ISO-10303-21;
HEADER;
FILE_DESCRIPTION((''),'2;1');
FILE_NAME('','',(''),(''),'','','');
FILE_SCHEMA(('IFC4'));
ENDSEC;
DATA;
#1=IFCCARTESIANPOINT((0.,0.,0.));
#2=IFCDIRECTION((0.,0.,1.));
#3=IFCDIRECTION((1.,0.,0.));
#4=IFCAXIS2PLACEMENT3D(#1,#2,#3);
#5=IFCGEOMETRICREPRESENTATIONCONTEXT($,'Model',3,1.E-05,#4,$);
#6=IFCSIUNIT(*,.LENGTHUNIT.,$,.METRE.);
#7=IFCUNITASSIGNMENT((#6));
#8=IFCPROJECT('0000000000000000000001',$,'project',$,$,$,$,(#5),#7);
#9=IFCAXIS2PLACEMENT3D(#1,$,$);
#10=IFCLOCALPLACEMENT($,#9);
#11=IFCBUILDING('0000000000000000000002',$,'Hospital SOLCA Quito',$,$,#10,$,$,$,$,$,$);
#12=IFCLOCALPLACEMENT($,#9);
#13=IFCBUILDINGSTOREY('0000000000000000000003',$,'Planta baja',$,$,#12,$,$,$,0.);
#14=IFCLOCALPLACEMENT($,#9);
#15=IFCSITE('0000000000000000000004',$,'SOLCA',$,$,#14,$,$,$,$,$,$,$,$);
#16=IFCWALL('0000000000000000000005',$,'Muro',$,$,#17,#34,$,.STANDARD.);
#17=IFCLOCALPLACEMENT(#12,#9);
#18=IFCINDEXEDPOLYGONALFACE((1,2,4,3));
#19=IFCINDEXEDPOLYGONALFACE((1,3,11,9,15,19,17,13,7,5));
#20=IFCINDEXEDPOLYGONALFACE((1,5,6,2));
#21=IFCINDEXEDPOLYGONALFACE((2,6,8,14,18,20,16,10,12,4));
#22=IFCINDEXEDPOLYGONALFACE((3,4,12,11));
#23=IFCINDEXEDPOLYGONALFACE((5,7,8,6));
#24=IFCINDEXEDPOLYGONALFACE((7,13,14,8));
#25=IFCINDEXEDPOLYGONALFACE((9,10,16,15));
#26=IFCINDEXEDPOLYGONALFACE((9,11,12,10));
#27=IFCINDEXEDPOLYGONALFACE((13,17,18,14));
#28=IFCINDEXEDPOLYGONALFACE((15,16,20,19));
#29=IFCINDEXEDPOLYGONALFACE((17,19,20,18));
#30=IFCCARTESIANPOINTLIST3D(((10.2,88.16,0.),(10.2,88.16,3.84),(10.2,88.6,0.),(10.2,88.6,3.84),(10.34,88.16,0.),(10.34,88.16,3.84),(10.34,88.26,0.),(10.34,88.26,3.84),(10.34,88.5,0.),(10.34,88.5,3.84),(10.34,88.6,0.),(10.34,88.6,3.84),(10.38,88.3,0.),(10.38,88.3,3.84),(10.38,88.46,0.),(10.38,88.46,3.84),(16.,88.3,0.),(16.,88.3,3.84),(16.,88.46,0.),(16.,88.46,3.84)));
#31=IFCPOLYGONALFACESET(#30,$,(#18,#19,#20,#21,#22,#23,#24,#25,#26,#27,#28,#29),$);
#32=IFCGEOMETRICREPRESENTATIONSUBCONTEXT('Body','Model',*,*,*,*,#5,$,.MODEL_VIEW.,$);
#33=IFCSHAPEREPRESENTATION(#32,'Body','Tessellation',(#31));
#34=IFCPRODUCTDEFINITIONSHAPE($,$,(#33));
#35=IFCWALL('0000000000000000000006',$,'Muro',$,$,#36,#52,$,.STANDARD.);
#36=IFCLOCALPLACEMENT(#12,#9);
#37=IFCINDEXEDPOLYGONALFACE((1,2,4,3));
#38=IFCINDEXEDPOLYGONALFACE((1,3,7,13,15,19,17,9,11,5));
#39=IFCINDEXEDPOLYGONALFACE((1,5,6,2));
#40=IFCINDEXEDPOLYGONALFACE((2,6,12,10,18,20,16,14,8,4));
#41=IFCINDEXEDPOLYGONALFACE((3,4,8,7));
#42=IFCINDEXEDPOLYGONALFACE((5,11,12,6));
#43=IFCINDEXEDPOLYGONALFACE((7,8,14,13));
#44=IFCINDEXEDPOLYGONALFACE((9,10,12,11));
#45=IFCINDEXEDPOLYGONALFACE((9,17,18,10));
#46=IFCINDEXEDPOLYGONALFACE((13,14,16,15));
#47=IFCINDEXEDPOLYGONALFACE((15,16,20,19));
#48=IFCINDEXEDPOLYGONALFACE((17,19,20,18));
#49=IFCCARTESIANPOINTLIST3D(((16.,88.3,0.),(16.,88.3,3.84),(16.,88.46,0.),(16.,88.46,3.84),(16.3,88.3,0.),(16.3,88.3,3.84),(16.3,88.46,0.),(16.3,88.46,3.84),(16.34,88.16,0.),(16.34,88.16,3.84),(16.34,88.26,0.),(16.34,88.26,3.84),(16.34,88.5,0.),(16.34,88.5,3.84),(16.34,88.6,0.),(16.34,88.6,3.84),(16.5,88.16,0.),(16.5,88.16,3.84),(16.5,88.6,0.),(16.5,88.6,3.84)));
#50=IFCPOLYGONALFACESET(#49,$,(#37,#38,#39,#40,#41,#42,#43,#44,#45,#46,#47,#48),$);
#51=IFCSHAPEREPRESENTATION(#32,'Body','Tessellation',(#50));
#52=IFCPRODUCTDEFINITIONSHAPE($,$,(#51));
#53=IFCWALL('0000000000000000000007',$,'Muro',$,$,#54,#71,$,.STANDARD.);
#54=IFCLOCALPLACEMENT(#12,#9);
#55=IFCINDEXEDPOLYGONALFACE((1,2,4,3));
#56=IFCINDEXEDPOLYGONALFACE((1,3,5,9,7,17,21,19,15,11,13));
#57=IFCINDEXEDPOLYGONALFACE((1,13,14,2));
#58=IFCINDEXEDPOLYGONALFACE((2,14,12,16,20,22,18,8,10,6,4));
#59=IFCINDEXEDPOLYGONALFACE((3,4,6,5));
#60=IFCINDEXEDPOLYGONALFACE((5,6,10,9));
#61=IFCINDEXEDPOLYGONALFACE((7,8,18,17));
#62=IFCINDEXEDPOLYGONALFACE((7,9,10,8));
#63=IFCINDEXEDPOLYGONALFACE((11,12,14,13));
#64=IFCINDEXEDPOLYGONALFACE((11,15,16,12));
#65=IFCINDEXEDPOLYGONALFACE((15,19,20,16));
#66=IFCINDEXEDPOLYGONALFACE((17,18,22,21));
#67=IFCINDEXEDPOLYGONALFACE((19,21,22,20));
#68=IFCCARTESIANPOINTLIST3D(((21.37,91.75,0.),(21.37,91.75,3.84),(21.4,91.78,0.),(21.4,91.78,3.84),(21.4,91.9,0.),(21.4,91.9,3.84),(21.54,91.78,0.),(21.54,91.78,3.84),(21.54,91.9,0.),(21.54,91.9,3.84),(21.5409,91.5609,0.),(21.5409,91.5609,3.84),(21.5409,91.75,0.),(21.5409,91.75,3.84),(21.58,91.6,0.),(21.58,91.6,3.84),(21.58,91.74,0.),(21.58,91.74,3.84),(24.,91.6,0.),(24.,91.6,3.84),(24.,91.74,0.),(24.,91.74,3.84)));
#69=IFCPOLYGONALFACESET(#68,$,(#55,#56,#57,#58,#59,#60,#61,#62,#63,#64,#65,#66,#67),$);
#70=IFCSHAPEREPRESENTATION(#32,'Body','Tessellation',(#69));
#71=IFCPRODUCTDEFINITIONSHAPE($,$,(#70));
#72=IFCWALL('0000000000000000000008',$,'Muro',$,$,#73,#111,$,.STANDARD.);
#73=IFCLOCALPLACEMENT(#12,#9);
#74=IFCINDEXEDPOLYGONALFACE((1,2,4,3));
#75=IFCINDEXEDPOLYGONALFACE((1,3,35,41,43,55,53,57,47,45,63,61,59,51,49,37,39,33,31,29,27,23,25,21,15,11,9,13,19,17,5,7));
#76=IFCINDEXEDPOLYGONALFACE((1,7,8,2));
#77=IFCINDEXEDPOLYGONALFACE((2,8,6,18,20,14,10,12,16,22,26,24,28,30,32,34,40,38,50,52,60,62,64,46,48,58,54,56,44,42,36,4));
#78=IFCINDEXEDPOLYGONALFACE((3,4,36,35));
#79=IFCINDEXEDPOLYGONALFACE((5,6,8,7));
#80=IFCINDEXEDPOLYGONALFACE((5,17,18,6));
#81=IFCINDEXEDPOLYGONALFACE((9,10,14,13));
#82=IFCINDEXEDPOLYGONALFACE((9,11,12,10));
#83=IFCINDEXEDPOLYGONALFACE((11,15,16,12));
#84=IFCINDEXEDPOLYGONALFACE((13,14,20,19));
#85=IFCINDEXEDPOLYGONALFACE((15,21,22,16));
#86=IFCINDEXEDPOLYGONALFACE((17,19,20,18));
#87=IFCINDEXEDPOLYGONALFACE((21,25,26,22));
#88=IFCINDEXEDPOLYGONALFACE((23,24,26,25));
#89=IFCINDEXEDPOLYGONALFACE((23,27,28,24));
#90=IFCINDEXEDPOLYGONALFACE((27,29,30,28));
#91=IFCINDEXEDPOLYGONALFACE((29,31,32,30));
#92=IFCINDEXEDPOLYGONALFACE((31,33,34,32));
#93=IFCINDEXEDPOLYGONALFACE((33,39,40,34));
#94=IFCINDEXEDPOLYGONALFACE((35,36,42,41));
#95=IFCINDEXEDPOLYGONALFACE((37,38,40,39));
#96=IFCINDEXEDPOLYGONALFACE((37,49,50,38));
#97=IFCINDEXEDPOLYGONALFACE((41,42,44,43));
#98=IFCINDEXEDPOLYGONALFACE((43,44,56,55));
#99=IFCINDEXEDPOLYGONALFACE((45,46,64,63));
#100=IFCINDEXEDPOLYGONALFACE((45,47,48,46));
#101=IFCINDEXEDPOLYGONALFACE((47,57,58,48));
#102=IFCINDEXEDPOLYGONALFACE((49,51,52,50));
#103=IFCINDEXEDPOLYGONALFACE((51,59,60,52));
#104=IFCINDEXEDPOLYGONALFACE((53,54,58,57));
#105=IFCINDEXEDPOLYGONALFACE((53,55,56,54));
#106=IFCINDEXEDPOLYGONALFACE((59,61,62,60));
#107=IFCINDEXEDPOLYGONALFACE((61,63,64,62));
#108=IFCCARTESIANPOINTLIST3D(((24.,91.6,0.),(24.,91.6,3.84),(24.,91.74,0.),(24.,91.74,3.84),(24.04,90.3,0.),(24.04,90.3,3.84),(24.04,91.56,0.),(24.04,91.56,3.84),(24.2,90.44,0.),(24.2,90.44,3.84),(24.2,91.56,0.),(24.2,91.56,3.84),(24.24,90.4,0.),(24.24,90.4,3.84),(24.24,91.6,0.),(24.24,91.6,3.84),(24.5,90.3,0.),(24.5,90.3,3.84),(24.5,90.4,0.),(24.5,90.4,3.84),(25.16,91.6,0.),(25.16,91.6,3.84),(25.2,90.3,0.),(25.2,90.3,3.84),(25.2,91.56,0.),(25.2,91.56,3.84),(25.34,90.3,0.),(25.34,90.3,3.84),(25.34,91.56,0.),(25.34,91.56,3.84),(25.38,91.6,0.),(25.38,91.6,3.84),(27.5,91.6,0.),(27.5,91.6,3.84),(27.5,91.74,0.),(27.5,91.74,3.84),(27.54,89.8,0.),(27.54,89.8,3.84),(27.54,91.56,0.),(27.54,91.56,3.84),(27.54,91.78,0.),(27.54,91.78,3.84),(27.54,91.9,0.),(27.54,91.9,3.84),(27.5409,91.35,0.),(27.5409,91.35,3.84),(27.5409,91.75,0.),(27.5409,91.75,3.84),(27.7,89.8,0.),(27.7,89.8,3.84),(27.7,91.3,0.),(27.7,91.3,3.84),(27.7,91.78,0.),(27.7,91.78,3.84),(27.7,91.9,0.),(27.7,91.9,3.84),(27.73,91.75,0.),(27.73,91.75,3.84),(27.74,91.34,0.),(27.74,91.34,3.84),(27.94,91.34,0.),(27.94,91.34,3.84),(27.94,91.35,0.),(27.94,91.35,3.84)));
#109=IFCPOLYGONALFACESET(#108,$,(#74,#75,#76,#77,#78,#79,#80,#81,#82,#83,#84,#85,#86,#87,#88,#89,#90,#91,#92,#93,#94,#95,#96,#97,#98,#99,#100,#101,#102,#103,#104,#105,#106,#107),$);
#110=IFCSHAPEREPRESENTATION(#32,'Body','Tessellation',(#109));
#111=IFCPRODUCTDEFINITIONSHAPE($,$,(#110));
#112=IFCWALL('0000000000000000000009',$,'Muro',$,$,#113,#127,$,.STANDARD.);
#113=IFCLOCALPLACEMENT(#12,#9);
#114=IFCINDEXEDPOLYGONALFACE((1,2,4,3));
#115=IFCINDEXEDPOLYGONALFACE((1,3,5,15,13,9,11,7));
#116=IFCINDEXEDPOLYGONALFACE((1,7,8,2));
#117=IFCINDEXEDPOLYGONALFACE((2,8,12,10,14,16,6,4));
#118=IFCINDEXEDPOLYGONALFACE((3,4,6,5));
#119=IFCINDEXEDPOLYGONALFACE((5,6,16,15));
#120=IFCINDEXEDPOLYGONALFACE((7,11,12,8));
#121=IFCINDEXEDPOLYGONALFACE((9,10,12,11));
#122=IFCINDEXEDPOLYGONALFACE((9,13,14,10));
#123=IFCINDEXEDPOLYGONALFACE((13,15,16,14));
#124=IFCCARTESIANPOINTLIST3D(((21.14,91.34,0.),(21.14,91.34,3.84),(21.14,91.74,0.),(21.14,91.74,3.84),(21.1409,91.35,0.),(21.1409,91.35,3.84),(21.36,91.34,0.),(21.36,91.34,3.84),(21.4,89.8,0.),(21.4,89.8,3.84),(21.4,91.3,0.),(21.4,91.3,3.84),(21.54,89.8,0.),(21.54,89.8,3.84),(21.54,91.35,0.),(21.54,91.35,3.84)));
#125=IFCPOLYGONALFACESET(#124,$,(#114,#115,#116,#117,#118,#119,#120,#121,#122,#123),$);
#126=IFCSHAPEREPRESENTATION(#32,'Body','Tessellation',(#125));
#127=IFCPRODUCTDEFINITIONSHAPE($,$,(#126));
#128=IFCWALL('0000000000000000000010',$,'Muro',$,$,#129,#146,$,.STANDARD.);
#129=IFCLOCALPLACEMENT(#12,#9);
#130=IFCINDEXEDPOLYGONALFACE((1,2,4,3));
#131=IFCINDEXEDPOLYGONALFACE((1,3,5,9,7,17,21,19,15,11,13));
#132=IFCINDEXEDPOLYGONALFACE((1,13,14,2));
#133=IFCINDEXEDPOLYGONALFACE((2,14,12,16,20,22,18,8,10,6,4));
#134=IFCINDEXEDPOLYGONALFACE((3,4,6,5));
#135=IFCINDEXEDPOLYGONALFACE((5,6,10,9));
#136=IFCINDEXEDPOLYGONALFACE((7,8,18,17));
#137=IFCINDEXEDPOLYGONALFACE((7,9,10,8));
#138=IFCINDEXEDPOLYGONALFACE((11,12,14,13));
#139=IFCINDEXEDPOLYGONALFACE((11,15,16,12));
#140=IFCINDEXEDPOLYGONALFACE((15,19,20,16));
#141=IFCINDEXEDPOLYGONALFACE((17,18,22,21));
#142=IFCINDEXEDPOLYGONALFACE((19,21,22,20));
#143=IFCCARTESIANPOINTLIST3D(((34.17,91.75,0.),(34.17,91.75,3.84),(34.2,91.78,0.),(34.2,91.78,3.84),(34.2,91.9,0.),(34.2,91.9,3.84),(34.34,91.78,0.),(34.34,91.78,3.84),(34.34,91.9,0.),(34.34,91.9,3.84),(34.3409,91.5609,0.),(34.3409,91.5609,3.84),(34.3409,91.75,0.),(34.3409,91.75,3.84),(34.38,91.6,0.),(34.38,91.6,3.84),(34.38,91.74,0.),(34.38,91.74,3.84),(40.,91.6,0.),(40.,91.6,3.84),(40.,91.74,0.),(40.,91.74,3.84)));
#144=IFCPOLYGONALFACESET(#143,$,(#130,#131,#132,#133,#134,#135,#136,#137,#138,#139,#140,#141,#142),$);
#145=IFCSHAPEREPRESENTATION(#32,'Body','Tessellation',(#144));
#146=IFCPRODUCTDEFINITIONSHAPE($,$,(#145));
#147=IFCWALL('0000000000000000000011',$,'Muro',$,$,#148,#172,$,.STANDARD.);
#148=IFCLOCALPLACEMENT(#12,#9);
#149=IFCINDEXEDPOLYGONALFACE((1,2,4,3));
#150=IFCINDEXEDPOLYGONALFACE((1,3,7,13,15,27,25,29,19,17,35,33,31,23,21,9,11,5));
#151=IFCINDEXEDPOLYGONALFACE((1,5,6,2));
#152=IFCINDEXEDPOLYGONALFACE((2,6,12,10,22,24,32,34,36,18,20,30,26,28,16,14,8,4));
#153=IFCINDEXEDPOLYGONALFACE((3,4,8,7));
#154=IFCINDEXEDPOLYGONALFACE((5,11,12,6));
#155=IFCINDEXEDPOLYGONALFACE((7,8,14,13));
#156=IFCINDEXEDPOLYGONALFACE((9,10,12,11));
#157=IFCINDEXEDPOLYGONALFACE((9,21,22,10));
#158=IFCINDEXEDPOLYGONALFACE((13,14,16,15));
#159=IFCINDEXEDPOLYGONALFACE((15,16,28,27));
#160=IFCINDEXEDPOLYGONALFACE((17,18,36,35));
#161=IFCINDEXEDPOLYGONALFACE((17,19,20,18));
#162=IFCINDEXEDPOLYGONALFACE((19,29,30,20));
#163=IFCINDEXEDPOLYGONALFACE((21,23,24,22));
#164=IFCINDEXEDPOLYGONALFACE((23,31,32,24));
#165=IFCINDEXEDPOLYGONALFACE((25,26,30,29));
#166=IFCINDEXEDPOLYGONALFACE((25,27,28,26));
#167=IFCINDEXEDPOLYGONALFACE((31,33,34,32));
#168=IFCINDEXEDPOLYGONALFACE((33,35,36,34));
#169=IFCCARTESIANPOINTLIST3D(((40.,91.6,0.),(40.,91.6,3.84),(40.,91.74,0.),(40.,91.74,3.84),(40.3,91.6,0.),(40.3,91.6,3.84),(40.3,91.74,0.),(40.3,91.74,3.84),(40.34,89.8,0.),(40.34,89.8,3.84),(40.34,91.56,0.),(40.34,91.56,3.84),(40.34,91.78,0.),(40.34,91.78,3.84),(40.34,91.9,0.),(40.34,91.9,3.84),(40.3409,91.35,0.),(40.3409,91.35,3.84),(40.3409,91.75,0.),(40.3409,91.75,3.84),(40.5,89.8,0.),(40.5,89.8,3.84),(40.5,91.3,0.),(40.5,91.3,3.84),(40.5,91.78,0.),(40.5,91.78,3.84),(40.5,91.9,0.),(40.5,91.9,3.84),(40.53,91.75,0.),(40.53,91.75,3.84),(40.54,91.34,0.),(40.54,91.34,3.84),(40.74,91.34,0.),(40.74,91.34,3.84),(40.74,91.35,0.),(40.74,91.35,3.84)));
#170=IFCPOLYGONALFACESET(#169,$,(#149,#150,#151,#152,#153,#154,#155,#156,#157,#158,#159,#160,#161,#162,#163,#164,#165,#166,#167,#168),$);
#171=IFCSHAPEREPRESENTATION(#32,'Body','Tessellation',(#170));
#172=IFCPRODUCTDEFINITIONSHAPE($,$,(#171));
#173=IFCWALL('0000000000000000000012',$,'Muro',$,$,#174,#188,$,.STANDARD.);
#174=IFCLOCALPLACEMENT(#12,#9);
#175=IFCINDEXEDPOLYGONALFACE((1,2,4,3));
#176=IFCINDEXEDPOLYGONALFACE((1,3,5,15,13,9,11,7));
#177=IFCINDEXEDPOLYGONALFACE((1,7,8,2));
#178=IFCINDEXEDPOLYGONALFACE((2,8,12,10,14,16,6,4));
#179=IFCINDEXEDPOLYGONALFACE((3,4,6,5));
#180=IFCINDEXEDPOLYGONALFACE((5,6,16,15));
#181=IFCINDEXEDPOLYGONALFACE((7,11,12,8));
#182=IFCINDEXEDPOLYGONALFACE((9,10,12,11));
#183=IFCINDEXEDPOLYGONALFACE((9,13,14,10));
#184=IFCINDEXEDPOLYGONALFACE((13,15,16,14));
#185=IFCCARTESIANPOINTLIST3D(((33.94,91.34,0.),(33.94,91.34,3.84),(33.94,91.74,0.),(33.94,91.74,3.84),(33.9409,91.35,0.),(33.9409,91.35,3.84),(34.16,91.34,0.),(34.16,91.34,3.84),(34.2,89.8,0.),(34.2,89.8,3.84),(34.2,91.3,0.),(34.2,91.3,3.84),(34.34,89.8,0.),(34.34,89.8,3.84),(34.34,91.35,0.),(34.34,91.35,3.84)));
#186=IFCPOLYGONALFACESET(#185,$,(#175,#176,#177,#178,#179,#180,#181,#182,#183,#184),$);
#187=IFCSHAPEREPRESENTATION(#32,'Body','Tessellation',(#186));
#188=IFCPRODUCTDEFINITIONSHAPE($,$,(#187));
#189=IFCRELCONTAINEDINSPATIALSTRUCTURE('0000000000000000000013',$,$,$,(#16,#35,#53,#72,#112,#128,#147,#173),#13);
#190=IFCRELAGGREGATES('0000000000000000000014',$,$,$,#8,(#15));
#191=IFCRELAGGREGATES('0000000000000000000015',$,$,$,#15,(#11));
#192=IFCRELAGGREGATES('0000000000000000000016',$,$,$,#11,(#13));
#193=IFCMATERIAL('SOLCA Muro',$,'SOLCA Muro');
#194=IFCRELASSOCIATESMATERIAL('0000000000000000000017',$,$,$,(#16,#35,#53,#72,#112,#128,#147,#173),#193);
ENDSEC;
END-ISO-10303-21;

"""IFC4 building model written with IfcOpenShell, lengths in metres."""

from ifc_helpers import new_model, si_unit, origin, origin_with_axes, place, context, subcontext, project, spatial, polyline, outline, extrude, material, element, save


model = new_model("IFC4")

# Units and contexts
model_context = context("Model", 3, precision=1e-05, world=origin_with_axes())
body_context = subcontext(model_context, "Body", "Model", "MODEL_VIEW")
ifc_project = project(units=[si_unit("LENGTHUNIT", "METRE")], contexts=[model_context])

# Site, building, storey
site_placement = place(None, origin())
site = spatial("IfcSite", under=ifc_project, at=site_placement, Name="SOLCA")
building_placement = place(None, origin())
building = spatial("IfcBuilding", under=site, at=building_placement, Name="Hospital SOLCA Quito")
storey_placement = place(None, origin())
storey = spatial("IfcBuildingStorey", under=building, at=storey_placement, Name="Planta baja", Elevation=0.0)

# Walls
ifc_material = material(Name="SOLCA Muro", Category="SOLCA Muro")
wall_1_placement = place(storey_placement, origin_with_axes())
element("IfcWall", 1, at=wall_1_placement, inside=storey, material=ifc_material, Name="Muro", PredefinedType="STANDARD", context=body_context, shape_type="SweptSolid", body=[
    extrude(outline(polyline([(10.38, 88.46), (16.0, 88.46), (16.0, 88.3), (10.38, 88.3), (10.34, 88.26), (10.34, 88.16), (10.2, 88.16), (10.2, 88.6), (10.34, 88.6), (10.34, 88.5), (10.38, 88.46)])), origin_with_axes(), (0.0, 0.0, 1.0), 3.84),
])
wall_2_placement = place(storey_placement, origin_with_axes())
element("IfcWall", 2, at=wall_2_placement, inside=storey, material=ifc_material, Name="Muro", PredefinedType="STANDARD", context=body_context, shape_type="SweptSolid", body=[
    extrude(outline(polyline([(16.3, 88.46), (16.34, 88.5), (16.34, 88.6), (16.5, 88.6), (16.5, 88.16), (16.34, 88.16), (16.34, 88.26), (16.3, 88.3), (16.0, 88.3), (16.0, 88.46), (16.3, 88.46)])), origin_with_axes(), (0.0, 0.0, 1.0), 3.84),
])
wall_3_placement = place(storey_placement, origin_with_axes())
element("IfcWall", 3, at=wall_3_placement, inside=storey, material=ifc_material, Name="Muro", PredefinedType="STANDARD", context=body_context, shape_type="SweptSolid", body=[
    extrude(outline(polyline([(21.58, 91.6), (21.5409, 91.5609), (21.5409, 91.75), (21.37, 91.75), (21.4, 91.78), (21.4, 91.9), (21.54, 91.9), (21.54, 91.78), (21.58, 91.74), (24.0, 91.74), (24.0, 91.6), (21.58, 91.6)])), origin_with_axes(), (0.0, 0.0, 1.0), 3.84),
])
wall_4_placement = place(storey_placement, origin_with_axes())
element("IfcWall", 4, at=wall_4_placement, inside=storey, material=ifc_material, Name="Muro", PredefinedType="STANDARD", context=body_context, shape_type="SweptSolid", body=[
    extrude(outline(polyline([(27.5, 91.6), (25.38, 91.6), (25.34, 91.56), (25.34, 90.3), (25.2, 90.3), (25.2, 91.56), (25.16, 91.6), (24.24, 91.6), (24.2, 91.56), (24.2, 90.44), (24.24, 90.4), (24.5, 90.4), (24.5, 90.3), (24.04, 90.3), (24.04, 91.56), (24.0, 91.6), (24.0, 91.74), (27.5, 91.74), (27.54, 91.78), (27.54, 91.9), (27.7, 91.9), (27.7, 91.78), (27.73, 91.75), (27.5409, 91.75), (27.5409, 91.35), (27.94, 91.35), (27.94, 91.34), (27.74, 91.34), (27.7, 91.3), (27.7, 89.8), (27.54, 89.8), (27.54, 91.56), (27.5, 91.6)])), origin_with_axes(), (0.0, 0.0, 1.0), 3.84),
])
wall_5_placement = place(storey_placement, origin_with_axes())
element("IfcWall", 5, at=wall_5_placement, inside=storey, material=ifc_material, Name="Muro", PredefinedType="STANDARD", context=body_context, shape_type="SweptSolid", body=[
    extrude(outline(polyline([(21.4, 91.3), (21.36, 91.34), (21.14, 91.34), (21.14, 91.74), (21.1409, 91.35), (21.54, 91.35), (21.54, 89.8), (21.4, 89.8), (21.4, 91.3)])), origin_with_axes(), (0.0, 0.0, 1.0), 3.84),
])
wall_6_placement = place(storey_placement, origin_with_axes())
element("IfcWall", 6, at=wall_6_placement, inside=storey, material=ifc_material, Name="Muro", PredefinedType="STANDARD", context=body_context, shape_type="SweptSolid", body=[
    extrude(outline(polyline([(34.38, 91.6), (34.3409, 91.5609), (34.3409, 91.75), (34.17, 91.75), (34.2, 91.78), (34.2, 91.9), (34.34, 91.9), (34.34, 91.78), (34.38, 91.74), (40.0, 91.74), (40.0, 91.6), (34.38, 91.6)])), origin_with_axes(), (0.0, 0.0, 1.0), 3.84),
])
wall_7_placement = place(storey_placement, origin_with_axes())
element("IfcWall", 7, at=wall_7_placement, inside=storey, material=ifc_material, Name="Muro", PredefinedType="STANDARD", context=body_context, shape_type="SweptSolid", body=[
    extrude(outline(polyline([(40.34, 91.56), (40.3, 91.6), (40.0, 91.6), (40.0, 91.74), (40.3, 91.74), (40.34, 91.78), (40.34, 91.9), (40.5, 91.9), (40.5, 91.78), (40.53, 91.75), (40.3409, 91.75), (40.3409, 91.35), (40.74, 91.35), (40.74, 91.34), (40.54, 91.34), (40.5, 91.3), (40.5, 89.8), (40.34, 89.8), (40.34, 91.56)])), origin_with_axes(), (0.0, 0.0, 1.0), 3.84),
])
wall_8_placement = place(storey_placement, origin_with_axes())
element("IfcWall", 8, at=wall_8_placement, inside=storey, material=ifc_material, Name="Muro", PredefinedType="STANDARD", context=body_context, shape_type="SweptSolid", body=[
    extrude(outline(polyline([(34.2, 91.3), (34.16, 91.34), (33.94, 91.34), (33.94, 91.74), (33.9409, 91.35), (34.34, 91.35), (34.34, 89.8), (34.2, 89.8), (34.2, 91.3)])), origin_with_axes(), (0.0, 0.0, 1.0), 3.84),
])

save(model, "model.ifc")
